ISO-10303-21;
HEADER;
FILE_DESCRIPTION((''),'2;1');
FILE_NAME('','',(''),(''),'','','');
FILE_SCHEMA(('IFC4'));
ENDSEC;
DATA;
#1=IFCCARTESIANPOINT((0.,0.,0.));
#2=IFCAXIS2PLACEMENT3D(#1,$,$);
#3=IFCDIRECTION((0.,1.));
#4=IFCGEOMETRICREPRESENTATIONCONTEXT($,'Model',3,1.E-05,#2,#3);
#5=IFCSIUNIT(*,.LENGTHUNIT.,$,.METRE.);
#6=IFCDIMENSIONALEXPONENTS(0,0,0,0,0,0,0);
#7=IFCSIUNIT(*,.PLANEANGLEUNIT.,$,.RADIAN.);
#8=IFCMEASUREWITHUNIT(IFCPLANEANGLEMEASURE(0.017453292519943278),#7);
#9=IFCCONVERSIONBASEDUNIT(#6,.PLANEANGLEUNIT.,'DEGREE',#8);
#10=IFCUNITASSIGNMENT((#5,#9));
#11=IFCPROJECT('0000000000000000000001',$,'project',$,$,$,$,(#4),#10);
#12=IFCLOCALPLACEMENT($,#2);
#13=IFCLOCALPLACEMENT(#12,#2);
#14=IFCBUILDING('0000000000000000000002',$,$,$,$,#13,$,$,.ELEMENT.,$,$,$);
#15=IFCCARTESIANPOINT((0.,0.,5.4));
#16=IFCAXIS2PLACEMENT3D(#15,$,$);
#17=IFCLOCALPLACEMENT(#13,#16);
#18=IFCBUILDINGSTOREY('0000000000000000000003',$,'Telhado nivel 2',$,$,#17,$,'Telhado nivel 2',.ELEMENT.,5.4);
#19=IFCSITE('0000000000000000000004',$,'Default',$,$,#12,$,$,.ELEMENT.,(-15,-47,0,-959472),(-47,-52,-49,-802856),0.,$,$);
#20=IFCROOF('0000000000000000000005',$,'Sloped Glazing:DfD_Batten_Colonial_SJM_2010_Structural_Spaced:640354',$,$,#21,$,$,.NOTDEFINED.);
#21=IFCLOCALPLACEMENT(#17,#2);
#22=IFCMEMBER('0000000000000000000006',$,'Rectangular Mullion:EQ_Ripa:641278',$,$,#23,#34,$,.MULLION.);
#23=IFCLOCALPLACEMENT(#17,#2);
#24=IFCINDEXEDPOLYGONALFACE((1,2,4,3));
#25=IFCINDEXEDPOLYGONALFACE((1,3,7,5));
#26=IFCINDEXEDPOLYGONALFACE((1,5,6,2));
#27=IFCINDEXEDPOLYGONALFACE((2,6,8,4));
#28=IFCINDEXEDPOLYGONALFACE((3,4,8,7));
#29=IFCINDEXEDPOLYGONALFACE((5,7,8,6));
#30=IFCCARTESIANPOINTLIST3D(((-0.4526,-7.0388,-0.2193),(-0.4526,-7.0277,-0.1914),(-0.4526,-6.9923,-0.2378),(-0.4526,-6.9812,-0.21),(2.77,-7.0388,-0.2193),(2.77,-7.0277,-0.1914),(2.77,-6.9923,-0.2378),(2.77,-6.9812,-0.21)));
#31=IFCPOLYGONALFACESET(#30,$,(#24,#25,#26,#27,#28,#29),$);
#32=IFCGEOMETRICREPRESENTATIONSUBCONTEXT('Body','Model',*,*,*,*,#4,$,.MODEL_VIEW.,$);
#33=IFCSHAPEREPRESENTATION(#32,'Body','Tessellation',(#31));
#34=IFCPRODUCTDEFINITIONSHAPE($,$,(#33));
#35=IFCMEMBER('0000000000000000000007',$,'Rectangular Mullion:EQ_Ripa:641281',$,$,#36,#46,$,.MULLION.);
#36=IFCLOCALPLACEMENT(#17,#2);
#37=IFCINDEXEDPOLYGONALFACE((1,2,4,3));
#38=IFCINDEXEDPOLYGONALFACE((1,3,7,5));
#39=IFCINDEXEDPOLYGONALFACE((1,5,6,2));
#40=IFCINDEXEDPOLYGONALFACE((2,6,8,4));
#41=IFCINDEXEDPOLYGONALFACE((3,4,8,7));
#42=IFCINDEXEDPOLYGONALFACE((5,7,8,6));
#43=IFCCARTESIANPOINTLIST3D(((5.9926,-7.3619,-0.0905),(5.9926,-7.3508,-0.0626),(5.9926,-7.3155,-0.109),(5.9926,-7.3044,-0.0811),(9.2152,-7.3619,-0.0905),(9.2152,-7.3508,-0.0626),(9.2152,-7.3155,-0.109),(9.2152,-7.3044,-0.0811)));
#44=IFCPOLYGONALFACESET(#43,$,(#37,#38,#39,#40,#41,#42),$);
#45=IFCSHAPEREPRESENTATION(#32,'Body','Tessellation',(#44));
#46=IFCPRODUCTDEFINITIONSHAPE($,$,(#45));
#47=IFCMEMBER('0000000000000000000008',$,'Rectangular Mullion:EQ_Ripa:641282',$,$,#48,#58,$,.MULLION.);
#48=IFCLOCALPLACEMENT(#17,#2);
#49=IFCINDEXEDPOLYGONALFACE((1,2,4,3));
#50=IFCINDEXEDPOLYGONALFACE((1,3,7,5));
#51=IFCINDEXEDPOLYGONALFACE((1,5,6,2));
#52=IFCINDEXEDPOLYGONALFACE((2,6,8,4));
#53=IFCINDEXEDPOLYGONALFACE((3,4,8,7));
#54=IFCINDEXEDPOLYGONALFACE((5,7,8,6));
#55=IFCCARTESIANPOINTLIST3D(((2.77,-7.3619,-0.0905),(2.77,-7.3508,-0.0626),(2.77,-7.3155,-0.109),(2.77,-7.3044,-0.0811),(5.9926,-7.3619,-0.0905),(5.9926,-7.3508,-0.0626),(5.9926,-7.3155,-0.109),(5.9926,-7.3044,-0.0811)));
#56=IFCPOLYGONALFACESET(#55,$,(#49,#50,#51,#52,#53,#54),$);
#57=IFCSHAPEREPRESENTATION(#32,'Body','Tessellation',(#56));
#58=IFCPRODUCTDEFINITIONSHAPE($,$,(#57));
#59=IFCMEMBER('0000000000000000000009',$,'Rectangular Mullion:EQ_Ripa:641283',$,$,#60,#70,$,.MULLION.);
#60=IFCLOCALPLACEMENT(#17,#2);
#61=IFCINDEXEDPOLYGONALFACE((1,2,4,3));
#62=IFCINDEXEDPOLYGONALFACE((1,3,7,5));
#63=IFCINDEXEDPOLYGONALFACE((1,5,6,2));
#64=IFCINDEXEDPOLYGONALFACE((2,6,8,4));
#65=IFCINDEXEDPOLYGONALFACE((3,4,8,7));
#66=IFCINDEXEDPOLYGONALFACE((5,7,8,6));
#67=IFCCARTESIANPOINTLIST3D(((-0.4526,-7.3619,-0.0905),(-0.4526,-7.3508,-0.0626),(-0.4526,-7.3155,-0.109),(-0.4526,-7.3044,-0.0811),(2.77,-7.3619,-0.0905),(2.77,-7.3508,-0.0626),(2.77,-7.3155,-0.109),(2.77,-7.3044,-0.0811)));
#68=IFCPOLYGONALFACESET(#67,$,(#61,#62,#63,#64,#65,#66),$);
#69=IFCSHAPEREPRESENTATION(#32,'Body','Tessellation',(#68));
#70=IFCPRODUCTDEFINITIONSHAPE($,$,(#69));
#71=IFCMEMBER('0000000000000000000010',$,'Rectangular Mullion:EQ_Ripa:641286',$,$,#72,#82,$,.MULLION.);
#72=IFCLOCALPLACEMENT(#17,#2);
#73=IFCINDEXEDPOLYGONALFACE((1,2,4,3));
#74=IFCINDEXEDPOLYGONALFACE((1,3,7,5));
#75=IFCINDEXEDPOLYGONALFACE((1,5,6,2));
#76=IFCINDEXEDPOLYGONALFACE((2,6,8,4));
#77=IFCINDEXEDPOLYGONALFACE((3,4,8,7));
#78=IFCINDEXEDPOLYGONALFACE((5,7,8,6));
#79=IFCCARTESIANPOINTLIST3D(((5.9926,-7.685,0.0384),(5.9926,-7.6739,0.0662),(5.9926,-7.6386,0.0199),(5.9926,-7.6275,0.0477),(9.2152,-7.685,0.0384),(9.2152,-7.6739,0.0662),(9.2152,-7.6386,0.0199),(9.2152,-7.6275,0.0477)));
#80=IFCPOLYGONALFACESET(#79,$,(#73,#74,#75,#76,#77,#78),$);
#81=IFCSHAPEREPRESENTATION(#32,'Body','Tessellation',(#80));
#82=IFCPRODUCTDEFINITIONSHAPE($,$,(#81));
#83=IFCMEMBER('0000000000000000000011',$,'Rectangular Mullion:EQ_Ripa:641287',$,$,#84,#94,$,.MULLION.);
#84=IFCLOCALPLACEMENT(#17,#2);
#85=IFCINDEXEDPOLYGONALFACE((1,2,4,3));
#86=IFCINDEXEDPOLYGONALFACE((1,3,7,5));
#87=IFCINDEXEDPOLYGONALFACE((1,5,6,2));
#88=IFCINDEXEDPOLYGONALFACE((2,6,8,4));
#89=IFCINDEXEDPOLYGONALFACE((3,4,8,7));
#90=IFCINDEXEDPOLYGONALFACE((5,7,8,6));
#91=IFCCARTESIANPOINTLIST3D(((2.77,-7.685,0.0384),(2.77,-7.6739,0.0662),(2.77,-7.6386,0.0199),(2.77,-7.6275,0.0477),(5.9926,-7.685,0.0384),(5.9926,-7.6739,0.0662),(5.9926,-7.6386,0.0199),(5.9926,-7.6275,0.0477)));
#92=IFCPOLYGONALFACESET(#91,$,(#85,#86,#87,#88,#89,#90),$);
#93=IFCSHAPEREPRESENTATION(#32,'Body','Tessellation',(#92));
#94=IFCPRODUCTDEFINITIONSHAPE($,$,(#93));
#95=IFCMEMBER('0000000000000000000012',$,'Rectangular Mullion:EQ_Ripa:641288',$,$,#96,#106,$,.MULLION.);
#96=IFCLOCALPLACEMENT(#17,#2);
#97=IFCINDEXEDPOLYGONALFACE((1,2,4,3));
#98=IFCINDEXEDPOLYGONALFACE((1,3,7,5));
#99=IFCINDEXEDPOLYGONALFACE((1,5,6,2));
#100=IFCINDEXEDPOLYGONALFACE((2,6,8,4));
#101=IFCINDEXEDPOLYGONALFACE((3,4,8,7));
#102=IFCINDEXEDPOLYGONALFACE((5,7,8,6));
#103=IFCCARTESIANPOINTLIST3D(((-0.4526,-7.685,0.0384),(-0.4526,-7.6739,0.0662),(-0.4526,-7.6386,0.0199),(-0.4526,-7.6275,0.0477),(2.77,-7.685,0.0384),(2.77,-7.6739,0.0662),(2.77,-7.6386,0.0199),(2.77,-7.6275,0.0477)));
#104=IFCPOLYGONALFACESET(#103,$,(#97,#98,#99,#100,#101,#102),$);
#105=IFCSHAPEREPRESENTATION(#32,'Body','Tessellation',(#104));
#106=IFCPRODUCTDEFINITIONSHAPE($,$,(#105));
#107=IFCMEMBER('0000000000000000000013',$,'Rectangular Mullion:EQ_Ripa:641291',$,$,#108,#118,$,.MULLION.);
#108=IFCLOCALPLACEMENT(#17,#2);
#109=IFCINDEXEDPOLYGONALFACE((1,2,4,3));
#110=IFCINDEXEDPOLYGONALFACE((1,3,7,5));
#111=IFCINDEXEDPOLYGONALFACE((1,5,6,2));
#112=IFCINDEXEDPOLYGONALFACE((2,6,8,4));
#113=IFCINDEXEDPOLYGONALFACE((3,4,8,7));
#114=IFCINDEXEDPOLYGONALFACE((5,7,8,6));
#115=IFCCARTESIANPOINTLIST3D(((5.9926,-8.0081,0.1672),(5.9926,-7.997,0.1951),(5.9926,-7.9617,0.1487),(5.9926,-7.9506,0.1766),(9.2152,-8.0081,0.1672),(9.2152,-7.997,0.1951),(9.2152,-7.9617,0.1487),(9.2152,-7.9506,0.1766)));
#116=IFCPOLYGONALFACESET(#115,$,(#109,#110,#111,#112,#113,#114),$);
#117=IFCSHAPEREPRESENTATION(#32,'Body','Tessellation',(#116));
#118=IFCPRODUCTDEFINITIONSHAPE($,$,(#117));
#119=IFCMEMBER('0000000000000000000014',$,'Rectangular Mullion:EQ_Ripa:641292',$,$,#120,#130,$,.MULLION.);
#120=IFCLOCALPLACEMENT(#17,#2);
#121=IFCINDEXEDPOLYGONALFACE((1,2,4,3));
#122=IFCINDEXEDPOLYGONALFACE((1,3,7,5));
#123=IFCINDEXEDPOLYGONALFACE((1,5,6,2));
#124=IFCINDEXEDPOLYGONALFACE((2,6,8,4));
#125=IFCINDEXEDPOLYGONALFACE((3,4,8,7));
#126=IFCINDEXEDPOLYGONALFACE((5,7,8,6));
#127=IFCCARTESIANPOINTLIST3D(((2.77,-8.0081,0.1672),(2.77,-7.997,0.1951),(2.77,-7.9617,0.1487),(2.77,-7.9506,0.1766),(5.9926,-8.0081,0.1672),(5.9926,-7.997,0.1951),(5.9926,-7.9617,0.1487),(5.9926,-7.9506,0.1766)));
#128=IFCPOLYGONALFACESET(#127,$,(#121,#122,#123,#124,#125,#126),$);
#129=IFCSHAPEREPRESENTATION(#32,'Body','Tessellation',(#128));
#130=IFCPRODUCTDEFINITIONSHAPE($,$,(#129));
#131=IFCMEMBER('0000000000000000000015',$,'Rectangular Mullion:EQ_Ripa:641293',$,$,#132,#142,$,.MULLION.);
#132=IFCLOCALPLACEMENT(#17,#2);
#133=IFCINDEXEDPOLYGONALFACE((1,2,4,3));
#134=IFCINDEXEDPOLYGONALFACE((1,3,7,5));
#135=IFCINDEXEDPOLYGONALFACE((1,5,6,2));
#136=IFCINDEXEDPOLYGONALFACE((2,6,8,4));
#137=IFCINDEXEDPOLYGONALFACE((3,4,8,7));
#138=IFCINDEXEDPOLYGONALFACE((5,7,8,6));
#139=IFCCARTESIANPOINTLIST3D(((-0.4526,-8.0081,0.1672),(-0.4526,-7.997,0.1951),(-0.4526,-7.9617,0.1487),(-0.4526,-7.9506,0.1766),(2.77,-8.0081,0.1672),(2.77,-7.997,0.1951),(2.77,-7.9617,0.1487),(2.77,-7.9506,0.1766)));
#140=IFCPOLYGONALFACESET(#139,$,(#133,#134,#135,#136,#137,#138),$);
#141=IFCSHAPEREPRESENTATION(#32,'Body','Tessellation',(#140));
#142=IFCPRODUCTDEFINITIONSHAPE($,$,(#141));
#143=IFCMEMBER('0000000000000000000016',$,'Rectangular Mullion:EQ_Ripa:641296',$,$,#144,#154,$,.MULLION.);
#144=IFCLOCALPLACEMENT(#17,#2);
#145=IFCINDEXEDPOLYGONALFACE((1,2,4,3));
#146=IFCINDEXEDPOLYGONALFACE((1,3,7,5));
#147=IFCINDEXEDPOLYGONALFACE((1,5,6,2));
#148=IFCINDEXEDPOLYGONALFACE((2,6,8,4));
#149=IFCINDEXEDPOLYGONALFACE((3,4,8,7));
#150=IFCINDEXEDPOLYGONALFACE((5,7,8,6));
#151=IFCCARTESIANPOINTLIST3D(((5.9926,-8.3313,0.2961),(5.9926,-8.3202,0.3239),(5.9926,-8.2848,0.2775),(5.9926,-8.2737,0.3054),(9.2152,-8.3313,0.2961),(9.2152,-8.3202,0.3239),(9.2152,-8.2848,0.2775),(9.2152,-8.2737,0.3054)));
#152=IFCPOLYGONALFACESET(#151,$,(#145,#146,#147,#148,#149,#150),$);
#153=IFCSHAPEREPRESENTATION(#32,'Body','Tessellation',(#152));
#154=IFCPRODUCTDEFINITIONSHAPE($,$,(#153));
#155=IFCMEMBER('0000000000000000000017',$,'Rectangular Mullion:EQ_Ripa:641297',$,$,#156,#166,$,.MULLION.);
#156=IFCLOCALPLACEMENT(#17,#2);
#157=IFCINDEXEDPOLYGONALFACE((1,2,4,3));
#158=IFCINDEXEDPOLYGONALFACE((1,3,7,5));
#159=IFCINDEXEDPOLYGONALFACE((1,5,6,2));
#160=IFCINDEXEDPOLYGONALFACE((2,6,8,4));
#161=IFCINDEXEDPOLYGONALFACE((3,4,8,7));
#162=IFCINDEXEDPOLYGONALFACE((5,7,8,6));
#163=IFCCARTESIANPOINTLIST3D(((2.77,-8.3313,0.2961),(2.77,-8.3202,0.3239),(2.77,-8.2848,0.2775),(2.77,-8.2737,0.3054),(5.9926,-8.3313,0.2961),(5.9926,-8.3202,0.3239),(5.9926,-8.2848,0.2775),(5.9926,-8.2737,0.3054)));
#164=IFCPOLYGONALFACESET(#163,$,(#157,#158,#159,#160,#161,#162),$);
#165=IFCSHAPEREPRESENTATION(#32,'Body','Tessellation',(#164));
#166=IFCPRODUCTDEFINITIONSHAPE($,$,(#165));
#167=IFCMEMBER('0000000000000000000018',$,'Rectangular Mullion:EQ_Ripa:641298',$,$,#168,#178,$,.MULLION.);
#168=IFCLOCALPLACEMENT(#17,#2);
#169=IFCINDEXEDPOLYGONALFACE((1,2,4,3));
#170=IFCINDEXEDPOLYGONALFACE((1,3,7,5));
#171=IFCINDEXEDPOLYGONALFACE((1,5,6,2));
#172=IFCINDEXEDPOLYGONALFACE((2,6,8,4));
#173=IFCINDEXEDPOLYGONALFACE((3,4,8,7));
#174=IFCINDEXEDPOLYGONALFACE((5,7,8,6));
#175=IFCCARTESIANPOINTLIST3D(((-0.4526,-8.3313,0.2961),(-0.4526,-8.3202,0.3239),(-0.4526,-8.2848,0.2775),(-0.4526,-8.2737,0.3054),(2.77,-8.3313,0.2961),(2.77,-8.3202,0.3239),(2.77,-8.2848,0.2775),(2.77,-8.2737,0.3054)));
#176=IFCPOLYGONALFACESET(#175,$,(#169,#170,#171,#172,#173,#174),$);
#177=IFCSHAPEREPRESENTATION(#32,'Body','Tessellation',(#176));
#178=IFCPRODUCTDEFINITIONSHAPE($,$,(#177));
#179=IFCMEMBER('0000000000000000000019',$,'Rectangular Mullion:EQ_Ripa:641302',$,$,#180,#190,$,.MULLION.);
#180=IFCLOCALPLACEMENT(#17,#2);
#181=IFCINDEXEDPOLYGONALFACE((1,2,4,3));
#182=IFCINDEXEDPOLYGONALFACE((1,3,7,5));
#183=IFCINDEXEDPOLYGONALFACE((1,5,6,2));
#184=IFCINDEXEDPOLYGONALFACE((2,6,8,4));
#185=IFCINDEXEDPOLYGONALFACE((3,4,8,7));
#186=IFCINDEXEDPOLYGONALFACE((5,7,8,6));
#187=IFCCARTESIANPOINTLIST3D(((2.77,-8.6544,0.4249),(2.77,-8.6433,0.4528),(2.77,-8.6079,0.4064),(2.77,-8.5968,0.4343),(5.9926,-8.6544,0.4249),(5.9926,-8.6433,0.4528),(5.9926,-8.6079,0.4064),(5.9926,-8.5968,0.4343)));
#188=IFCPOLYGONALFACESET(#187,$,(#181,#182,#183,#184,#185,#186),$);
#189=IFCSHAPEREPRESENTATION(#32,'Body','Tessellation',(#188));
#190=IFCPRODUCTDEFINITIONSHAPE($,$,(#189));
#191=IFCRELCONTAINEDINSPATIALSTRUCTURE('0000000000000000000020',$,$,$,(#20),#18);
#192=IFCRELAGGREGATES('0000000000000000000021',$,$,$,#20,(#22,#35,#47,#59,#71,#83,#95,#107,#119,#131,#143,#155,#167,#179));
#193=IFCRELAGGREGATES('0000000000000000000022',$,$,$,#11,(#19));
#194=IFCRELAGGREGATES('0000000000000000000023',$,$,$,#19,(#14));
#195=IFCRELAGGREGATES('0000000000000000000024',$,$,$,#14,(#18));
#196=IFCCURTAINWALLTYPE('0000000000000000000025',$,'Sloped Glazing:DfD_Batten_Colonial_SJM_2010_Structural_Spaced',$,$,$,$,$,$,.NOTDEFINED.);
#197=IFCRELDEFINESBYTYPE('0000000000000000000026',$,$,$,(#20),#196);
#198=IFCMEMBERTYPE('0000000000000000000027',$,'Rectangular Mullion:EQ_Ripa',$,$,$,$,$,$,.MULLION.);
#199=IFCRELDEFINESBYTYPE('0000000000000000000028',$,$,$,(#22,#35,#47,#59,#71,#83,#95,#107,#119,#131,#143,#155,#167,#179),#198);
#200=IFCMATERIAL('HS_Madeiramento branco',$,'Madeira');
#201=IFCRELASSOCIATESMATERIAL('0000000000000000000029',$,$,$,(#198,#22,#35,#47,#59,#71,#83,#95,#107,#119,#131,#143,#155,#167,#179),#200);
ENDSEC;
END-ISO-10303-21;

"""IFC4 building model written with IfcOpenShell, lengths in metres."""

from ifc_helpers import new_model, entity, si_unit, converted_unit, direction, frame, origin, place, context, subcontext, project, spatial, indexed_curve, outline, extrude, source, transform, mapped, material, type_object, type_shapes, element, aggregate, save


model = new_model("IFC4")

# Units and contexts
model_context = context("Model", 3, precision=1e-05, world=origin(), true_north=direction((0.0, 1.0)))
body_context = subcontext(model_context, "Body", "Model", "MODEL_VIEW")
ifc_project = project(units=[si_unit("LENGTHUNIT", "METRE"), converted_unit("PLANEANGLEUNIT", "DEGREE", entity("IfcPlaneAngleMeasure", 0.017453292519943278), si_unit("PLANEANGLEUNIT", "RADIAN"), dimensions=[0, 0, 0, 0, 0, 0, 0])], contexts=[model_context])

# Site, building, storey
site_placement = place(None, origin())
site = spatial("IfcSite", under=ifc_project, at=site_placement, Name="Default", CompositionType="ELEMENT", RefLatitude=(-15, -47, 0, -959472), RefLongitude=(-47, -52, -49, -802856), RefElevation=0.0)
building_placement = place(site_placement, origin())
building = spatial("IfcBuilding", under=site, at=building_placement, CompositionType="ELEMENT")
storey_placement = place(building_placement, frame((0.0, 0.0, 5.4)))
storey = spatial("IfcBuildingStorey", under=building, at=storey_placement, Name="Telhado nivel 2", LongName="Telhado nivel 2", CompositionType="ELEMENT", Elevation=5.4)

# Roof, members
curtain_wall_type = type_object("IfcCurtainWallType", Name="Sloped Glazing:DfD_Batten_Colonial_SJM_2010_Structural_Spaced", PredefinedType="NOTDEFINED")
roof_placement = place(storey_placement, frame((0.0, 0.0, -5.4)))
roof = element("IfcRoof", 1, at=roof_placement, inside=storey, type_object=curtain_wall_type, Name="Sloped Glazing:DfD_Batten_Colonial_SJM_2010_Structural_Spaced:640354", PredefinedType="NOTDEFINED")
ifc_material = material(Name="HS_Madeiramento branco", Category="Madeira")
member_type_1 = type_object("IfcMemberType", Name="Rectangular Mullion:EQ_Ripa", PredefinedType="MULLION", material=ifc_material)
shared_shape_1 = source(origin(), body_context, "Body", "SweptSolid", [
    extrude(outline(indexed_curve([(-0.025, -0.015), (0.025, -0.015), (0.025, 0.015), (-0.025, 0.015), (-0.025, -0.015)], self_intersect=False)), frame((0.0, 0.0, -3.2226), z_axis=(0.0, 0.0, 1.0), x_axis=(-1.0, 0.0, 0.0)), (0.0, 0.0, 1.0), 3.2226),
])
type_shapes(member_type_1, [shared_shape_1])
member_1_placement = place(roof_placement, frame((2.77, -7.01, 5.1854), z_axis=(1.0, 0.0, 0.0), x_axis=(0.0, -0.928878, 0.370385)))
member_1 = element("IfcMember", 2, at=member_1_placement, type_object=member_type_1, material=ifc_material, Name="Rectangular Mullion:EQ_Ripa:641278", PredefinedType="MULLION", context=body_context, shape_type="MappedRepresentation", body=[
    mapped(shared_shape_1, transform((0.0, 0.0, 0.0), scale=1.0)),
])
member_2_placement = place(roof_placement, frame((9.2152, -7.3331, 5.3142), z_axis=(1.0, 0.0, 0.0), x_axis=(0.0, -0.928878, 0.370385)))
member_2 = element("IfcMember", 3, at=member_2_placement, type_object=member_type_1, material=ifc_material, Name="Rectangular Mullion:EQ_Ripa:641281", PredefinedType="MULLION", context=body_context, shape_type="MappedRepresentation", body=[
    mapped(shared_shape_1, transform((0.0, 0.0, 0.0), scale=1.0)),
])
member_3_placement = place(roof_placement, frame((5.9926, -7.3331, 5.3142), z_axis=(1.0, 0.0, 0.0), x_axis=(0.0, -0.928878, 0.370385)))
member_3 = element("IfcMember", 4, at=member_3_placement, type_object=member_type_1, material=ifc_material, Name="Rectangular Mullion:EQ_Ripa:641282", PredefinedType="MULLION", context=body_context, shape_type="MappedRepresentation", body=[
    mapped(shared_shape_1, transform((0.0, 0.0, 0.0), scale=1.0)),
])
member_4_placement = place(roof_placement, frame((2.77, -7.3331, 5.3142), z_axis=(1.0, 0.0, 0.0), x_axis=(0.0, -0.928878, 0.370385)))
member_4 = element("IfcMember", 5, at=member_4_placement, type_object=member_type_1, material=ifc_material, Name="Rectangular Mullion:EQ_Ripa:641283", PredefinedType="MULLION", context=body_context, shape_type="MappedRepresentation", body=[
    mapped(shared_shape_1, transform((0.0, 0.0, 0.0), scale=1.0)),
])
member_5_placement = place(roof_placement, frame((9.2152, -7.6562, 5.4431), z_axis=(1.0, 0.0, 0.0), x_axis=(0.0, -0.928878, 0.370385)))
member_5 = element("IfcMember", 6, at=member_5_placement, type_object=member_type_1, material=ifc_material, Name="Rectangular Mullion:EQ_Ripa:641286", PredefinedType="MULLION", context=body_context, shape_type="MappedRepresentation", body=[
    mapped(shared_shape_1, transform((0.0, 0.0, 0.0), scale=1.0)),
])
member_6_placement = place(roof_placement, frame((5.9926, -7.6562, 5.4431), z_axis=(1.0, 0.0, 0.0), x_axis=(0.0, -0.928878, 0.370385)))
member_6 = element("IfcMember", 7, at=member_6_placement, type_object=member_type_1, material=ifc_material, Name="Rectangular Mullion:EQ_Ripa:641287", PredefinedType="MULLION", context=body_context, shape_type="MappedRepresentation", body=[
    mapped(shared_shape_1, transform((0.0, 0.0, 0.0), scale=1.0)),
])
member_7_placement = place(roof_placement, frame((2.77, -7.6562, 5.4431), z_axis=(1.0, 0.0, 0.0), x_axis=(0.0, -0.928878, 0.370385)))
member_7 = element("IfcMember", 8, at=member_7_placement, type_object=member_type_1, material=ifc_material, Name="Rectangular Mullion:EQ_Ripa:641288", PredefinedType="MULLION", context=body_context, shape_type="MappedRepresentation", body=[
    mapped(shared_shape_1, transform((0.0, 0.0, 0.0), scale=1.0)),
])
member_8_placement = place(roof_placement, frame((9.2152, -7.9794, 5.5719), z_axis=(1.0, 0.0, 0.0), x_axis=(0.0, -0.928878, 0.370385)))
member_8 = element("IfcMember", 9, at=member_8_placement, type_object=member_type_1, material=ifc_material, Name="Rectangular Mullion:EQ_Ripa:641291", PredefinedType="MULLION", context=body_context, shape_type="MappedRepresentation", body=[
    mapped(shared_shape_1, transform((0.0, 0.0, 0.0), scale=1.0)),
])
member_9_placement = place(roof_placement, frame((5.9926, -7.9794, 5.5719), z_axis=(1.0, 0.0, 0.0), x_axis=(0.0, -0.928878, 0.370385)))
member_9 = element("IfcMember", 10, at=member_9_placement, type_object=member_type_1, material=ifc_material, Name="Rectangular Mullion:EQ_Ripa:641292", PredefinedType="MULLION", context=body_context, shape_type="MappedRepresentation", body=[
    mapped(shared_shape_1, transform((0.0, 0.0, 0.0), scale=1.0)),
])
member_10_placement = place(roof_placement, frame((2.77, -7.9794, 5.5719), z_axis=(1.0, 0.0, 0.0), x_axis=(0.0, -0.928878, 0.370385)))
member_10 = element("IfcMember", 11, at=member_10_placement, type_object=member_type_1, material=ifc_material, Name="Rectangular Mullion:EQ_Ripa:641293", PredefinedType="MULLION", context=body_context, shape_type="MappedRepresentation", body=[
    mapped(shared_shape_1, transform((0.0, 0.0, 0.0), scale=1.0)),
])
member_11_placement = place(roof_placement, frame((9.2152, -8.3025, 5.7007), z_axis=(1.0, 0.0, 0.0), x_axis=(0.0, -0.928878, 0.370385)))
member_11 = element("IfcMember", 12, at=member_11_placement, type_object=member_type_1, material=ifc_material, Name="Rectangular Mullion:EQ_Ripa:641296", PredefinedType="MULLION", context=body_context, shape_type="MappedRepresentation", body=[
    mapped(shared_shape_1, transform((0.0, 0.0, 0.0), scale=1.0)),
])
member_12_placement = place(roof_placement, frame((5.9926, -8.3025, 5.7007), z_axis=(1.0, 0.0, 0.0), x_axis=(0.0, -0.928878, 0.370385)))
member_12 = element("IfcMember", 13, at=member_12_placement, type_object=member_type_1, material=ifc_material, Name="Rectangular Mullion:EQ_Ripa:641297", PredefinedType="MULLION", context=body_context, shape_type="MappedRepresentation", body=[
    mapped(shared_shape_1, transform((0.0, 0.0, 0.0), scale=1.0)),
])
member_13_placement = place(roof_placement, frame((2.77, -8.3025, 5.7007), z_axis=(1.0, 0.0, 0.0), x_axis=(0.0, -0.928878, 0.370385)))
member_13 = element("IfcMember", 14, at=member_13_placement, type_object=member_type_1, material=ifc_material, Name="Rectangular Mullion:EQ_Ripa:641298", PredefinedType="MULLION", context=body_context, shape_type="MappedRepresentation", body=[
    mapped(shared_shape_1, transform((0.0, 0.0, 0.0), scale=1.0)),
])
member_14_placement = place(roof_placement, frame((5.9926, -8.6256, 5.8296), z_axis=(1.0, 0.0, 0.0), x_axis=(0.0, -0.928878, 0.370385)))
member_14 = element("IfcMember", 15, at=member_14_placement, type_object=member_type_1, material=ifc_material, Name="Rectangular Mullion:EQ_Ripa:641302", PredefinedType="MULLION", context=body_context, shape_type="MappedRepresentation", body=[
    mapped(shared_shape_1, transform((0.0, 0.0, 0.0), scale=1.0)),
])
aggregate(roof, [member_1, member_2, member_3, member_4, member_5, member_6, member_7, member_8, member_9, member_10, member_11, member_12, member_13, member_14])

save(model, "model.ifc")
